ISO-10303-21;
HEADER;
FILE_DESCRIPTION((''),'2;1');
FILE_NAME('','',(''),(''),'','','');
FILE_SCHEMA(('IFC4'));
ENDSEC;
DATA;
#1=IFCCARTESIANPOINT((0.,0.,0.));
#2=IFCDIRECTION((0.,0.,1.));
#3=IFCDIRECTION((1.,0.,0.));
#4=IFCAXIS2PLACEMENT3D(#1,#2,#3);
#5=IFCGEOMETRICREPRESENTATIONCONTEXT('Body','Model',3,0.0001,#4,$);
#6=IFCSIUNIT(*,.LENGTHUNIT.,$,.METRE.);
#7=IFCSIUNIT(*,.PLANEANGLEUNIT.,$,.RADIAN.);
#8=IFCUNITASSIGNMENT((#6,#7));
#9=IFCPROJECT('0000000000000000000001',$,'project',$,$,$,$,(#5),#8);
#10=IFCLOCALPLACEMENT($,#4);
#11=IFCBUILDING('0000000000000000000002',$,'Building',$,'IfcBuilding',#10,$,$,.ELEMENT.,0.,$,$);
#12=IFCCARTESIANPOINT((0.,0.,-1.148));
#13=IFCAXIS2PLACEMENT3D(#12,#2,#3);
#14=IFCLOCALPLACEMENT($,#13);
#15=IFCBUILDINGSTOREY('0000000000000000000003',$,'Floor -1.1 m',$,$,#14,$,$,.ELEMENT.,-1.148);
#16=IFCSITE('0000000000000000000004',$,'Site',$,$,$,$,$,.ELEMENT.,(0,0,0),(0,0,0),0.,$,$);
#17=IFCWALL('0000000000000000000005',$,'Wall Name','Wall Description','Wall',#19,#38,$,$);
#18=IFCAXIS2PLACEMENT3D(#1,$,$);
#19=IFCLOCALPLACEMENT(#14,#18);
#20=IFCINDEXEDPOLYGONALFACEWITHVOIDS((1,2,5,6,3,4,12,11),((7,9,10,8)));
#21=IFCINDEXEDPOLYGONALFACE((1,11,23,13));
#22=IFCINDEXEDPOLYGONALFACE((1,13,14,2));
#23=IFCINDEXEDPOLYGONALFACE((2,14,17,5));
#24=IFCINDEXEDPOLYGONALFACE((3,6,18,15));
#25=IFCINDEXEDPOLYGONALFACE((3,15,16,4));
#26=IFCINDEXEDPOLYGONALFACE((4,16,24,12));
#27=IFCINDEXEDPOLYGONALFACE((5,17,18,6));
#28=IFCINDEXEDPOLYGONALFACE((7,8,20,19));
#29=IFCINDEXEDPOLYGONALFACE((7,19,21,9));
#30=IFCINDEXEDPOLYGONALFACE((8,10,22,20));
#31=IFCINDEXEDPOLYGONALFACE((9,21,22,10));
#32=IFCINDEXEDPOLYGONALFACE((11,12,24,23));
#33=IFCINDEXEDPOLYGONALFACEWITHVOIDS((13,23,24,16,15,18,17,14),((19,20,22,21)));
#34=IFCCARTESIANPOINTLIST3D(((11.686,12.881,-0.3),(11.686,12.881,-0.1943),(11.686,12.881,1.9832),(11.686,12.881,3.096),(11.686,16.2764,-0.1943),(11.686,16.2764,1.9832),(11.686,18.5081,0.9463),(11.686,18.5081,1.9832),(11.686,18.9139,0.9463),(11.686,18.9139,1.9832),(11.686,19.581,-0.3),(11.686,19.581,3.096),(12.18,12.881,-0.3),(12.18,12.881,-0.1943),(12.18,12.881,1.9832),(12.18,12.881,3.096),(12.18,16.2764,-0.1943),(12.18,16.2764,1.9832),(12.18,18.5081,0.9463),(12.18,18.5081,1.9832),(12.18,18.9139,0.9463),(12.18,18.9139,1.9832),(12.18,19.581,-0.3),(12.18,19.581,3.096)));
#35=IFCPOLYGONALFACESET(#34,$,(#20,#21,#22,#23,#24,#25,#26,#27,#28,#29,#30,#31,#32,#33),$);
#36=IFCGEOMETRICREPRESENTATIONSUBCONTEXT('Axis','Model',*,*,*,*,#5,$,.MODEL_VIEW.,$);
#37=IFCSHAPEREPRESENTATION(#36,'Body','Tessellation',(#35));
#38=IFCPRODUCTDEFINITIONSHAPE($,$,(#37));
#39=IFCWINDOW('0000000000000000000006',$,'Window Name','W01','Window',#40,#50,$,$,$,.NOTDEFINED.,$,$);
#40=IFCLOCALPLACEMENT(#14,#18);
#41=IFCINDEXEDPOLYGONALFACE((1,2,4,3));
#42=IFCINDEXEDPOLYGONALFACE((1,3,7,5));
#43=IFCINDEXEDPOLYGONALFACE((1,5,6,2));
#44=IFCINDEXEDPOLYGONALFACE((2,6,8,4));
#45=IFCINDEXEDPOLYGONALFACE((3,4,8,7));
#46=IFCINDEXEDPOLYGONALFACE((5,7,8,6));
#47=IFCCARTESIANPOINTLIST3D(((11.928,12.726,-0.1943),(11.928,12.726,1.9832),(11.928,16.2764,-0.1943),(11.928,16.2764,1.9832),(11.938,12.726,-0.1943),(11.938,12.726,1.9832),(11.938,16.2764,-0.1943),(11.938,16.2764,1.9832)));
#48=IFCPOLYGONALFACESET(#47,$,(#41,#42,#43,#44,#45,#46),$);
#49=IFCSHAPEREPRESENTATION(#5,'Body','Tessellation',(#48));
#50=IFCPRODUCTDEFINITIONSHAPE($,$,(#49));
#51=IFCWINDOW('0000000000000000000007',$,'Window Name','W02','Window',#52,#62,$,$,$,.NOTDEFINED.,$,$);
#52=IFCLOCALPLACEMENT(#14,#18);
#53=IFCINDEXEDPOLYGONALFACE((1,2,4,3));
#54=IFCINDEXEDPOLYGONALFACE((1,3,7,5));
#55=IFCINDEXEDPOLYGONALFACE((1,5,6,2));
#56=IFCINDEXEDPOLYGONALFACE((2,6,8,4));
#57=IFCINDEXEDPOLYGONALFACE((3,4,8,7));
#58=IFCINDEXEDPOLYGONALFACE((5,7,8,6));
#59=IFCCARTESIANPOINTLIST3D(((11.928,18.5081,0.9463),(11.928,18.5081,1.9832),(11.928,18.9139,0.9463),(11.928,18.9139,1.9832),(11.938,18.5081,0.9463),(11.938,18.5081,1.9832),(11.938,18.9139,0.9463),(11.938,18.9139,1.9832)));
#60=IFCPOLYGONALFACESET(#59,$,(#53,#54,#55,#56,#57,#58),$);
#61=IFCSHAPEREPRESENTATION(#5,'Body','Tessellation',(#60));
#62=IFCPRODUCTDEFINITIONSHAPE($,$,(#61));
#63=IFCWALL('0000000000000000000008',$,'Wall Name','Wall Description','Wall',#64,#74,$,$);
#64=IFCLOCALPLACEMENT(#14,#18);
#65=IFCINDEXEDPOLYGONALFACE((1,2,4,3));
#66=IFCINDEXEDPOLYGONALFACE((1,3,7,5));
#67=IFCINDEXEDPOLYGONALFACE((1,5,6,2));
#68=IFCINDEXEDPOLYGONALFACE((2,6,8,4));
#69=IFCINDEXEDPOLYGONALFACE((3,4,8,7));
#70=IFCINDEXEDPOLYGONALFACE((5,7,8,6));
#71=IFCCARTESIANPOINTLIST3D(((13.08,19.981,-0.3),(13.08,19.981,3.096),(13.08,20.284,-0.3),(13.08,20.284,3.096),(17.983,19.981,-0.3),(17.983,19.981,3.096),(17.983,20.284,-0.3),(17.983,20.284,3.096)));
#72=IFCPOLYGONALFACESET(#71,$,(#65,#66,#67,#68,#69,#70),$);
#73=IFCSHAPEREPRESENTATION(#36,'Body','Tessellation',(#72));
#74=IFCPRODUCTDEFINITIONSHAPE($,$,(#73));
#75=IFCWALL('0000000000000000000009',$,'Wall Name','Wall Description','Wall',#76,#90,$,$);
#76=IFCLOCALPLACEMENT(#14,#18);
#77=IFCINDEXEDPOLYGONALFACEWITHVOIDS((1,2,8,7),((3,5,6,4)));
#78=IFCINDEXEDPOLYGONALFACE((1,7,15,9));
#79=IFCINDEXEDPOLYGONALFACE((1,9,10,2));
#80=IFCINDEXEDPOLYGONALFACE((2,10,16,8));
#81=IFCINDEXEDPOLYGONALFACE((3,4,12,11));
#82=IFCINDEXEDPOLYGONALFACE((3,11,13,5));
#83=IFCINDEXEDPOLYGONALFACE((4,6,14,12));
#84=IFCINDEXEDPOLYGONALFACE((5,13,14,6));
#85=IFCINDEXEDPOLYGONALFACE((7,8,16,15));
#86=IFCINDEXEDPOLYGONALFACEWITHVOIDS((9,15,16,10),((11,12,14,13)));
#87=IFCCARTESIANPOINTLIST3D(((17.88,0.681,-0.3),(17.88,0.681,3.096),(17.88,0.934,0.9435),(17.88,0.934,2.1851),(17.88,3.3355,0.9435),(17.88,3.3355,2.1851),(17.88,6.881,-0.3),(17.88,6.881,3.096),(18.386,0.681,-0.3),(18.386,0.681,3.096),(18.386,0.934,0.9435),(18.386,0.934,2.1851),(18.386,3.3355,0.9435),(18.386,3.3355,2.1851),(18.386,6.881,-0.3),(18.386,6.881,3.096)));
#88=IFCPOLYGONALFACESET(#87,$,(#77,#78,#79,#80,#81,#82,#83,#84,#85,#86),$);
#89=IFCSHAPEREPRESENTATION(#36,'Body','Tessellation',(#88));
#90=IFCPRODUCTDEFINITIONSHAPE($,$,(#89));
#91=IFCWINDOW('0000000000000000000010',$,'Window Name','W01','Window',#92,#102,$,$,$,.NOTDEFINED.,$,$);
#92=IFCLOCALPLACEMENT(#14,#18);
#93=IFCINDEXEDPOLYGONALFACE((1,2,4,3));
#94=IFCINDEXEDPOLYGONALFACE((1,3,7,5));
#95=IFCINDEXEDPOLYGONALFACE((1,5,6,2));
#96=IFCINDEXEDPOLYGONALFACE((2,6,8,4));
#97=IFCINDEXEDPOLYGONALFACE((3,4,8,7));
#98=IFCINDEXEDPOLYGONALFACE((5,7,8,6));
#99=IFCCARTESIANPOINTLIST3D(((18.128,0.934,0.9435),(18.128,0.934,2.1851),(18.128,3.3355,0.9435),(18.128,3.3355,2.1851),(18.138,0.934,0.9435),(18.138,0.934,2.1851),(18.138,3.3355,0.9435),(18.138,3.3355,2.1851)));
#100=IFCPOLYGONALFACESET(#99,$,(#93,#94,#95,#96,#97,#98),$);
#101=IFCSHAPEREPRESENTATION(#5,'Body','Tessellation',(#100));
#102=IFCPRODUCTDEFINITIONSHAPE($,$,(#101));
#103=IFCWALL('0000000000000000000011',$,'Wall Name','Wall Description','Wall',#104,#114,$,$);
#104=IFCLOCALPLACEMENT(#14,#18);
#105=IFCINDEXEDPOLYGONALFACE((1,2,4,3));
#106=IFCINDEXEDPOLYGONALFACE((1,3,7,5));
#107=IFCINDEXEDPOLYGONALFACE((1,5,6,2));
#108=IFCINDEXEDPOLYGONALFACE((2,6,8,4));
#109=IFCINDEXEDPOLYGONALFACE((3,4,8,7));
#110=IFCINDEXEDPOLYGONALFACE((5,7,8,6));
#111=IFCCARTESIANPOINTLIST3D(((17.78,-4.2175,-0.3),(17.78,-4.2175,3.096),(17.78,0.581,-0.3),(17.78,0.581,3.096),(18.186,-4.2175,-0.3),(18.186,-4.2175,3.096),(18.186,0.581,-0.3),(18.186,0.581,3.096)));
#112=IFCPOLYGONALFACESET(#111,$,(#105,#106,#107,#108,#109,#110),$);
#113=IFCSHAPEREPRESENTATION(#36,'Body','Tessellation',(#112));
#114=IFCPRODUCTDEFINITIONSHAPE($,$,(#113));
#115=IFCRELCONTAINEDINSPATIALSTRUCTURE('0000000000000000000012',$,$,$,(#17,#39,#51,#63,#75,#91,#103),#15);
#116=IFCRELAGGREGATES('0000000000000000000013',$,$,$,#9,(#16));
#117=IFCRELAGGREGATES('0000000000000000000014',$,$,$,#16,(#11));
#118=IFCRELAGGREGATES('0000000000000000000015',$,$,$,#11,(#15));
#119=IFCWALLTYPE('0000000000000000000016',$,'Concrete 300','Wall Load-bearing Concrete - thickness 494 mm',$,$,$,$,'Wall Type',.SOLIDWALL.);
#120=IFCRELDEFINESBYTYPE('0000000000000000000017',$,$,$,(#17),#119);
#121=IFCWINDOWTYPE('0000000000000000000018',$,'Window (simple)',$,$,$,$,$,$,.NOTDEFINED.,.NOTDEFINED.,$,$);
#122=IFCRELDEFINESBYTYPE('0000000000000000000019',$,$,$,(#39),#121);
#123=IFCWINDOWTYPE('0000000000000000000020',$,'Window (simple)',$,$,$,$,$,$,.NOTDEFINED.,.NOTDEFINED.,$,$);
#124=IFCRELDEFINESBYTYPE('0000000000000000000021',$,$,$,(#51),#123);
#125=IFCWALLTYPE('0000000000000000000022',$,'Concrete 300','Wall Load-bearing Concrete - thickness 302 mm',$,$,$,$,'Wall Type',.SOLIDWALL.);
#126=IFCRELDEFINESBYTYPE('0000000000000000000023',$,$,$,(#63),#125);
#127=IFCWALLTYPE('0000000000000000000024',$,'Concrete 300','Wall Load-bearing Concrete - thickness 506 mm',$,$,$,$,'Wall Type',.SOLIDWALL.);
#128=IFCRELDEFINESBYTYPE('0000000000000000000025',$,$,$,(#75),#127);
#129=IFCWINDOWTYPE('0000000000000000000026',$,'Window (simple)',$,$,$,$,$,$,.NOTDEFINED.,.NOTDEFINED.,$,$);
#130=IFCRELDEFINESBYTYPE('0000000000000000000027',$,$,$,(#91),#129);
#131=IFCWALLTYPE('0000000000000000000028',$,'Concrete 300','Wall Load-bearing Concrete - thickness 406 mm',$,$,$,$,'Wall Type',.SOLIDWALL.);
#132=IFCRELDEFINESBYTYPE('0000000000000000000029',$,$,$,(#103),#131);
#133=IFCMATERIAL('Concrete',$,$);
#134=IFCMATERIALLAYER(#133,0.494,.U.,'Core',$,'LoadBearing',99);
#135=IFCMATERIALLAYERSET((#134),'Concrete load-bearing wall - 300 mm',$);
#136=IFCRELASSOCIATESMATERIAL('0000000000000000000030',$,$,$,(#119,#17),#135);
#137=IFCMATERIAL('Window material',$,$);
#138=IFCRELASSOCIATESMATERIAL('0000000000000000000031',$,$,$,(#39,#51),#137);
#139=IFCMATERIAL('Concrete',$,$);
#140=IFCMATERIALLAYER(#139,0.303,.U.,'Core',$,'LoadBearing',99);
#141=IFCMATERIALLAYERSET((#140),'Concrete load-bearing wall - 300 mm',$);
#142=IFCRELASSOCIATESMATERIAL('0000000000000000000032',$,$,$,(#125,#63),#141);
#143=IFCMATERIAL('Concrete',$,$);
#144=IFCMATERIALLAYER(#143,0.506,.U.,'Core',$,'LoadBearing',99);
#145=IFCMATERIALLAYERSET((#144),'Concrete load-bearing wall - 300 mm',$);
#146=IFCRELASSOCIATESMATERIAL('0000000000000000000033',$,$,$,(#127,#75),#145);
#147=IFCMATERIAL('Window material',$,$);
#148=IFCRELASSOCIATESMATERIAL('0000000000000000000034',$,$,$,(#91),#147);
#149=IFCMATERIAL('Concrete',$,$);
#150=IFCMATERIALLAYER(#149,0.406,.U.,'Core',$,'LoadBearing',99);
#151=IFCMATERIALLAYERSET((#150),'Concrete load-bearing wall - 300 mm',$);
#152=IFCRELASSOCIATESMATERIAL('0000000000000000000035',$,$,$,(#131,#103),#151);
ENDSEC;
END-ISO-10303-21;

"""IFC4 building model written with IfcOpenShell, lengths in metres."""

from ifc_helpers import new_model, si_unit, frame, frame_2d, origin_with_axes, place, context, subcontext, project, spatial, polyline, rectangle, outline, extrude, material, layer, layer_set, layer_usage, type_object, element, fill, save


model = new_model("IFC4")

# Units and contexts
model_context = context("Model", 3, precision=0.0001, world=origin_with_axes(), identifier="Body")
axis_context = subcontext(model_context, "Axis", "Model", "MODEL_VIEW")
ifc_project = project(units=[si_unit("LENGTHUNIT", "METRE"), si_unit("PLANEANGLEUNIT", "RADIAN")], contexts=[model_context])

# Site, building, storey
site = spatial("IfcSite", under=ifc_project, Name="Site", CompositionType="ELEMENT", RefLatitude=(0, 0, 0), RefLongitude=(0, 0, 0), RefElevation=0.0)
building_placement = place(None, origin_with_axes())
building = spatial("IfcBuilding", under=site, at=building_placement, Name="Building", ObjectType="IfcBuilding", CompositionType="ELEMENT", ElevationOfRefHeight=0.0)
storey_placement = place(None, frame((0.0, 0.0, -1.148), z_axis=(0.0, 0.0, 1.0), x_axis=(1.0, 0.0, 0.0)))
storey = spatial("IfcBuildingStorey", under=building, at=storey_placement, Name="Floor -1.1 m", CompositionType="ELEMENT", Elevation=-1.148)

# Wall, openings, windows
ifc_material_1 = material(Name="Concrete")
ifc_layer_1 = layer(ifc_material_1, 0.494, ventilated="UNKNOWN", Name="Core", Category="LoadBearing", Priority=99)
ifc_layer_set_1 = layer_set([ifc_layer_1], Name="Concrete load-bearing wall - 300 mm")
ifc_layer_usage_1 = layer_usage(ifc_layer_set_1, "AXIS2", "POSITIVE", -0.247)
wall_type_1 = type_object("IfcWallType", Name="Concrete 300", Description="Wall Load-bearing Concrete - thickness 494 mm", ElementType="Wall Type", PredefinedType="SOLIDWALL", material=ifc_layer_set_1)
wall_1_placement = place(None, frame((0.0, 0.0, -1.448)))
wall_1 = element("IfcWall", 1, at=wall_1_placement, inside=storey, type_object=wall_type_1, material=ifc_layer_usage_1, Name="Wall Name", Description="Wall Description", ObjectType="Wall", context=axis_context, shape_type="SweptSolid", body=[
    extrude(rectangle(XDim=6.7, YDim=0.494, at=frame_2d((11.933, 16.231), x_axis=(0.0, 1.0))), None, (0.0, 0.0, 1.0), 3.396),
])
placement_1 = place(wall_1_placement, frame((11.933, 12.881, 0.0), z_axis=(0.0, 0.0, 1.0), x_axis=(1.0, 0.0, 0.0)))
opening_1 = element("IfcOpeningElement", 2, at=placement_1, cuts=wall_1, PredefinedType="OPENING", context=model_context, shape_type="SweptSolid", body=[
    extrude(outline(polyline([(0.0, -0.247), (0.0, 0.247), (3.5504, 0.247), (3.5504, -0.247), (0.0, -0.247)])), frame((0.0, -0.155, 0.1057), z_axis=(0.0, 0.0, 1.0), x_axis=(0.0, 1.0, 0.0)), (0.0, 0.0, 1.0), 2.1775),
])
placement_2 = place(wall_1_placement, frame((11.933, 12.881, 0.0), z_axis=(0.0, 0.0, 1.0), x_axis=(1.0, 0.0, 0.0)))
opening_2 = element("IfcOpeningElement", 3, at=placement_2, cuts=wall_1, PredefinedType="OPENING", context=model_context, shape_type="SweptSolid", body=[
    extrude(outline(polyline([(0.0, -0.247), (0.0, 0.247), (0.4058, 0.247), (0.4058, -0.247), (0.0, -0.247)])), frame((0.0, 5.6271, 1.2463), z_axis=(0.0, 0.0, 1.0), x_axis=(0.0, 1.0, 0.0)), (0.0, 0.0, 1.0), 1.0369),
])
ifc_material_2 = material(Name="Window material")
window_type_1 = type_object("IfcWindowType", Name="Window (simple)", PredefinedType="NOTDEFINED")
window_1 = element("IfcWindow", 4, at=placement_1, inside=storey, type_object=window_type_1, material=ifc_material_2, Name="Window Name", Description="W01", ObjectType="Window", PredefinedType="NOTDEFINED", context=model_context, shape_type="SweptSolid", body=[
    extrude(outline(polyline([(0.0, -0.005), (0.0, 0.005), (3.5504, 0.005), (3.5504, -0.005), (0.0, -0.005)])), frame((0.0, -0.155, 0.1057), z_axis=(0.0, 0.0, 1.0), x_axis=(0.0, 1.0, 0.0)), (0.0, 0.0, 1.0), 2.1775),
])
fill(opening_1, window_1)
window_type_2 = type_object("IfcWindowType", Name="Window (simple)", PredefinedType="NOTDEFINED")
window_2 = element("IfcWindow", 5, at=placement_2, inside=storey, type_object=window_type_2, material=ifc_material_2, Name="Window Name", Description="W02", ObjectType="Window", PredefinedType="NOTDEFINED", context=model_context, shape_type="SweptSolid", body=[
    extrude(outline(polyline([(0.0, -0.005), (0.0, 0.005), (0.4058, 0.005), (0.4058, -0.005), (0.0, -0.005)])), frame((0.0, 5.6271, 1.2463), z_axis=(0.0, 0.0, 1.0), x_axis=(0.0, 1.0, 0.0)), (0.0, 0.0, 1.0), 1.0369),
])
fill(opening_2, window_2)

# Wall
ifc_material_3 = material(Name="Concrete")
ifc_layer_2 = layer(ifc_material_3, 0.303, ventilated="UNKNOWN", Name="Core", Category="LoadBearing", Priority=99)
ifc_layer_set_2 = layer_set([ifc_layer_2], Name="Concrete load-bearing wall - 300 mm")
ifc_layer_usage_2 = layer_usage(ifc_layer_set_2, "AXIS2", "POSITIVE", -0.1515)
wall_type_2 = type_object("IfcWallType", Name="Concrete 300", Description="Wall Load-bearing Concrete - thickness 302 mm", ElementType="Wall Type", PredefinedType="SOLIDWALL", material=ifc_layer_set_2)
wall_2_placement = place(None, frame((0.0, 0.0, -1.448)))
element("IfcWall", 6, at=wall_2_placement, inside=storey, type_object=wall_type_2, material=ifc_layer_usage_2, Name="Wall Name", Description="Wall Description", ObjectType="Wall", context=axis_context, shape_type="SweptSolid", body=[
    extrude(rectangle(XDim=4.903, YDim=0.303, at=frame_2d((15.5315, 20.1325), x_axis=(1.0, 0.0))), None, (0.0, 0.0, 1.0), 3.396),
])

# Wall, opening, window
ifc_material_4 = material(Name="Concrete")
ifc_layer_3 = layer(ifc_material_4, 0.506, ventilated="UNKNOWN", Name="Core", Category="LoadBearing", Priority=99)
ifc_layer_set_3 = layer_set([ifc_layer_3], Name="Concrete load-bearing wall - 300 mm")
ifc_layer_usage_3 = layer_usage(ifc_layer_set_3, "AXIS2", "POSITIVE", -0.253)
wall_type_3 = type_object("IfcWallType", Name="Concrete 300", Description="Wall Load-bearing Concrete - thickness 506 mm", ElementType="Wall Type", PredefinedType="SOLIDWALL", material=ifc_layer_set_3)
wall_3_placement = place(None, frame((0.0, 0.0, -1.448)))
wall_3 = element("IfcWall", 7, at=wall_3_placement, inside=storey, type_object=wall_type_3, material=ifc_layer_usage_3, Name="Wall Name", Description="Wall Description", ObjectType="Wall", context=axis_context, shape_type="SweptSolid", body=[
    extrude(rectangle(XDim=6.2, YDim=0.506, at=frame_2d((18.133, 3.781), x_axis=(0.0, 1.0))), None, (0.0, 0.0, 1.0), 3.396),
])
placement_3 = place(wall_3_placement, frame((18.133, 0.681, 0.0), z_axis=(0.0, 0.0, 1.0), x_axis=(1.0, 0.0, 0.0)))
opening_3 = element("IfcOpeningElement", 8, at=placement_3, cuts=wall_3, PredefinedType="OPENING", context=model_context, shape_type="SweptSolid", body=[
    extrude(outline(polyline([(0.0, -0.253), (0.0, 0.253), (2.4015, 0.253), (2.4015, -0.253), (0.0, -0.253)])), frame((0.0, 0.253, 1.2435), z_axis=(0.0, 0.0, 1.0), x_axis=(0.0, 1.0, 0.0)), (0.0, 0.0, 1.0), 1.2415),
])
ifc_material_5 = material(Name="Window material")
window_type_3 = type_object("IfcWindowType", Name="Window (simple)", PredefinedType="NOTDEFINED")
window_3 = element("IfcWindow", 9, at=placement_3, inside=storey, type_object=window_type_3, material=ifc_material_5, Name="Window Name", Description="W01", ObjectType="Window", PredefinedType="NOTDEFINED", context=model_context, shape_type="SweptSolid", body=[
    extrude(outline(polyline([(0.0, -0.005), (0.0, 0.005), (2.4015, 0.005), (2.4015, -0.005), (0.0, -0.005)])), frame((0.0, 0.253, 1.2435), z_axis=(0.0, 0.0, 1.0), x_axis=(0.0, 1.0, 0.0)), (0.0, 0.0, 1.0), 1.2415),
])
fill(opening_3, window_3)

# Wall
ifc_material_6 = material(Name="Concrete")
ifc_layer_4 = layer(ifc_material_6, 0.406, ventilated="UNKNOWN", Name="Core", Category="LoadBearing", Priority=99)
ifc_layer_set_4 = layer_set([ifc_layer_4], Name="Concrete load-bearing wall - 300 mm")
ifc_layer_usage_4 = layer_usage(ifc_layer_set_4, "AXIS2", "POSITIVE", -0.203)
wall_type_4 = type_object("IfcWallType", Name="Concrete 300", Description="Wall Load-bearing Concrete - thickness 406 mm", ElementType="Wall Type", PredefinedType="SOLIDWALL", material=ifc_layer_set_4)
wall_4_placement = place(None, frame((0.0, 0.0, -1.448)))
element("IfcWall", 10, at=wall_4_placement, inside=storey, type_object=wall_type_4, material=ifc_layer_usage_4, Name="Wall Name", Description="Wall Description", ObjectType="Wall", context=axis_context, shape_type="SweptSolid", body=[
    extrude(rectangle(XDim=4.7985, YDim=0.406, at=frame_2d((17.983, -1.8182), x_axis=(0.0, 1.0))), None, (0.0, 0.0, 1.0), 3.396),
])

save(model, "model.ifc")
